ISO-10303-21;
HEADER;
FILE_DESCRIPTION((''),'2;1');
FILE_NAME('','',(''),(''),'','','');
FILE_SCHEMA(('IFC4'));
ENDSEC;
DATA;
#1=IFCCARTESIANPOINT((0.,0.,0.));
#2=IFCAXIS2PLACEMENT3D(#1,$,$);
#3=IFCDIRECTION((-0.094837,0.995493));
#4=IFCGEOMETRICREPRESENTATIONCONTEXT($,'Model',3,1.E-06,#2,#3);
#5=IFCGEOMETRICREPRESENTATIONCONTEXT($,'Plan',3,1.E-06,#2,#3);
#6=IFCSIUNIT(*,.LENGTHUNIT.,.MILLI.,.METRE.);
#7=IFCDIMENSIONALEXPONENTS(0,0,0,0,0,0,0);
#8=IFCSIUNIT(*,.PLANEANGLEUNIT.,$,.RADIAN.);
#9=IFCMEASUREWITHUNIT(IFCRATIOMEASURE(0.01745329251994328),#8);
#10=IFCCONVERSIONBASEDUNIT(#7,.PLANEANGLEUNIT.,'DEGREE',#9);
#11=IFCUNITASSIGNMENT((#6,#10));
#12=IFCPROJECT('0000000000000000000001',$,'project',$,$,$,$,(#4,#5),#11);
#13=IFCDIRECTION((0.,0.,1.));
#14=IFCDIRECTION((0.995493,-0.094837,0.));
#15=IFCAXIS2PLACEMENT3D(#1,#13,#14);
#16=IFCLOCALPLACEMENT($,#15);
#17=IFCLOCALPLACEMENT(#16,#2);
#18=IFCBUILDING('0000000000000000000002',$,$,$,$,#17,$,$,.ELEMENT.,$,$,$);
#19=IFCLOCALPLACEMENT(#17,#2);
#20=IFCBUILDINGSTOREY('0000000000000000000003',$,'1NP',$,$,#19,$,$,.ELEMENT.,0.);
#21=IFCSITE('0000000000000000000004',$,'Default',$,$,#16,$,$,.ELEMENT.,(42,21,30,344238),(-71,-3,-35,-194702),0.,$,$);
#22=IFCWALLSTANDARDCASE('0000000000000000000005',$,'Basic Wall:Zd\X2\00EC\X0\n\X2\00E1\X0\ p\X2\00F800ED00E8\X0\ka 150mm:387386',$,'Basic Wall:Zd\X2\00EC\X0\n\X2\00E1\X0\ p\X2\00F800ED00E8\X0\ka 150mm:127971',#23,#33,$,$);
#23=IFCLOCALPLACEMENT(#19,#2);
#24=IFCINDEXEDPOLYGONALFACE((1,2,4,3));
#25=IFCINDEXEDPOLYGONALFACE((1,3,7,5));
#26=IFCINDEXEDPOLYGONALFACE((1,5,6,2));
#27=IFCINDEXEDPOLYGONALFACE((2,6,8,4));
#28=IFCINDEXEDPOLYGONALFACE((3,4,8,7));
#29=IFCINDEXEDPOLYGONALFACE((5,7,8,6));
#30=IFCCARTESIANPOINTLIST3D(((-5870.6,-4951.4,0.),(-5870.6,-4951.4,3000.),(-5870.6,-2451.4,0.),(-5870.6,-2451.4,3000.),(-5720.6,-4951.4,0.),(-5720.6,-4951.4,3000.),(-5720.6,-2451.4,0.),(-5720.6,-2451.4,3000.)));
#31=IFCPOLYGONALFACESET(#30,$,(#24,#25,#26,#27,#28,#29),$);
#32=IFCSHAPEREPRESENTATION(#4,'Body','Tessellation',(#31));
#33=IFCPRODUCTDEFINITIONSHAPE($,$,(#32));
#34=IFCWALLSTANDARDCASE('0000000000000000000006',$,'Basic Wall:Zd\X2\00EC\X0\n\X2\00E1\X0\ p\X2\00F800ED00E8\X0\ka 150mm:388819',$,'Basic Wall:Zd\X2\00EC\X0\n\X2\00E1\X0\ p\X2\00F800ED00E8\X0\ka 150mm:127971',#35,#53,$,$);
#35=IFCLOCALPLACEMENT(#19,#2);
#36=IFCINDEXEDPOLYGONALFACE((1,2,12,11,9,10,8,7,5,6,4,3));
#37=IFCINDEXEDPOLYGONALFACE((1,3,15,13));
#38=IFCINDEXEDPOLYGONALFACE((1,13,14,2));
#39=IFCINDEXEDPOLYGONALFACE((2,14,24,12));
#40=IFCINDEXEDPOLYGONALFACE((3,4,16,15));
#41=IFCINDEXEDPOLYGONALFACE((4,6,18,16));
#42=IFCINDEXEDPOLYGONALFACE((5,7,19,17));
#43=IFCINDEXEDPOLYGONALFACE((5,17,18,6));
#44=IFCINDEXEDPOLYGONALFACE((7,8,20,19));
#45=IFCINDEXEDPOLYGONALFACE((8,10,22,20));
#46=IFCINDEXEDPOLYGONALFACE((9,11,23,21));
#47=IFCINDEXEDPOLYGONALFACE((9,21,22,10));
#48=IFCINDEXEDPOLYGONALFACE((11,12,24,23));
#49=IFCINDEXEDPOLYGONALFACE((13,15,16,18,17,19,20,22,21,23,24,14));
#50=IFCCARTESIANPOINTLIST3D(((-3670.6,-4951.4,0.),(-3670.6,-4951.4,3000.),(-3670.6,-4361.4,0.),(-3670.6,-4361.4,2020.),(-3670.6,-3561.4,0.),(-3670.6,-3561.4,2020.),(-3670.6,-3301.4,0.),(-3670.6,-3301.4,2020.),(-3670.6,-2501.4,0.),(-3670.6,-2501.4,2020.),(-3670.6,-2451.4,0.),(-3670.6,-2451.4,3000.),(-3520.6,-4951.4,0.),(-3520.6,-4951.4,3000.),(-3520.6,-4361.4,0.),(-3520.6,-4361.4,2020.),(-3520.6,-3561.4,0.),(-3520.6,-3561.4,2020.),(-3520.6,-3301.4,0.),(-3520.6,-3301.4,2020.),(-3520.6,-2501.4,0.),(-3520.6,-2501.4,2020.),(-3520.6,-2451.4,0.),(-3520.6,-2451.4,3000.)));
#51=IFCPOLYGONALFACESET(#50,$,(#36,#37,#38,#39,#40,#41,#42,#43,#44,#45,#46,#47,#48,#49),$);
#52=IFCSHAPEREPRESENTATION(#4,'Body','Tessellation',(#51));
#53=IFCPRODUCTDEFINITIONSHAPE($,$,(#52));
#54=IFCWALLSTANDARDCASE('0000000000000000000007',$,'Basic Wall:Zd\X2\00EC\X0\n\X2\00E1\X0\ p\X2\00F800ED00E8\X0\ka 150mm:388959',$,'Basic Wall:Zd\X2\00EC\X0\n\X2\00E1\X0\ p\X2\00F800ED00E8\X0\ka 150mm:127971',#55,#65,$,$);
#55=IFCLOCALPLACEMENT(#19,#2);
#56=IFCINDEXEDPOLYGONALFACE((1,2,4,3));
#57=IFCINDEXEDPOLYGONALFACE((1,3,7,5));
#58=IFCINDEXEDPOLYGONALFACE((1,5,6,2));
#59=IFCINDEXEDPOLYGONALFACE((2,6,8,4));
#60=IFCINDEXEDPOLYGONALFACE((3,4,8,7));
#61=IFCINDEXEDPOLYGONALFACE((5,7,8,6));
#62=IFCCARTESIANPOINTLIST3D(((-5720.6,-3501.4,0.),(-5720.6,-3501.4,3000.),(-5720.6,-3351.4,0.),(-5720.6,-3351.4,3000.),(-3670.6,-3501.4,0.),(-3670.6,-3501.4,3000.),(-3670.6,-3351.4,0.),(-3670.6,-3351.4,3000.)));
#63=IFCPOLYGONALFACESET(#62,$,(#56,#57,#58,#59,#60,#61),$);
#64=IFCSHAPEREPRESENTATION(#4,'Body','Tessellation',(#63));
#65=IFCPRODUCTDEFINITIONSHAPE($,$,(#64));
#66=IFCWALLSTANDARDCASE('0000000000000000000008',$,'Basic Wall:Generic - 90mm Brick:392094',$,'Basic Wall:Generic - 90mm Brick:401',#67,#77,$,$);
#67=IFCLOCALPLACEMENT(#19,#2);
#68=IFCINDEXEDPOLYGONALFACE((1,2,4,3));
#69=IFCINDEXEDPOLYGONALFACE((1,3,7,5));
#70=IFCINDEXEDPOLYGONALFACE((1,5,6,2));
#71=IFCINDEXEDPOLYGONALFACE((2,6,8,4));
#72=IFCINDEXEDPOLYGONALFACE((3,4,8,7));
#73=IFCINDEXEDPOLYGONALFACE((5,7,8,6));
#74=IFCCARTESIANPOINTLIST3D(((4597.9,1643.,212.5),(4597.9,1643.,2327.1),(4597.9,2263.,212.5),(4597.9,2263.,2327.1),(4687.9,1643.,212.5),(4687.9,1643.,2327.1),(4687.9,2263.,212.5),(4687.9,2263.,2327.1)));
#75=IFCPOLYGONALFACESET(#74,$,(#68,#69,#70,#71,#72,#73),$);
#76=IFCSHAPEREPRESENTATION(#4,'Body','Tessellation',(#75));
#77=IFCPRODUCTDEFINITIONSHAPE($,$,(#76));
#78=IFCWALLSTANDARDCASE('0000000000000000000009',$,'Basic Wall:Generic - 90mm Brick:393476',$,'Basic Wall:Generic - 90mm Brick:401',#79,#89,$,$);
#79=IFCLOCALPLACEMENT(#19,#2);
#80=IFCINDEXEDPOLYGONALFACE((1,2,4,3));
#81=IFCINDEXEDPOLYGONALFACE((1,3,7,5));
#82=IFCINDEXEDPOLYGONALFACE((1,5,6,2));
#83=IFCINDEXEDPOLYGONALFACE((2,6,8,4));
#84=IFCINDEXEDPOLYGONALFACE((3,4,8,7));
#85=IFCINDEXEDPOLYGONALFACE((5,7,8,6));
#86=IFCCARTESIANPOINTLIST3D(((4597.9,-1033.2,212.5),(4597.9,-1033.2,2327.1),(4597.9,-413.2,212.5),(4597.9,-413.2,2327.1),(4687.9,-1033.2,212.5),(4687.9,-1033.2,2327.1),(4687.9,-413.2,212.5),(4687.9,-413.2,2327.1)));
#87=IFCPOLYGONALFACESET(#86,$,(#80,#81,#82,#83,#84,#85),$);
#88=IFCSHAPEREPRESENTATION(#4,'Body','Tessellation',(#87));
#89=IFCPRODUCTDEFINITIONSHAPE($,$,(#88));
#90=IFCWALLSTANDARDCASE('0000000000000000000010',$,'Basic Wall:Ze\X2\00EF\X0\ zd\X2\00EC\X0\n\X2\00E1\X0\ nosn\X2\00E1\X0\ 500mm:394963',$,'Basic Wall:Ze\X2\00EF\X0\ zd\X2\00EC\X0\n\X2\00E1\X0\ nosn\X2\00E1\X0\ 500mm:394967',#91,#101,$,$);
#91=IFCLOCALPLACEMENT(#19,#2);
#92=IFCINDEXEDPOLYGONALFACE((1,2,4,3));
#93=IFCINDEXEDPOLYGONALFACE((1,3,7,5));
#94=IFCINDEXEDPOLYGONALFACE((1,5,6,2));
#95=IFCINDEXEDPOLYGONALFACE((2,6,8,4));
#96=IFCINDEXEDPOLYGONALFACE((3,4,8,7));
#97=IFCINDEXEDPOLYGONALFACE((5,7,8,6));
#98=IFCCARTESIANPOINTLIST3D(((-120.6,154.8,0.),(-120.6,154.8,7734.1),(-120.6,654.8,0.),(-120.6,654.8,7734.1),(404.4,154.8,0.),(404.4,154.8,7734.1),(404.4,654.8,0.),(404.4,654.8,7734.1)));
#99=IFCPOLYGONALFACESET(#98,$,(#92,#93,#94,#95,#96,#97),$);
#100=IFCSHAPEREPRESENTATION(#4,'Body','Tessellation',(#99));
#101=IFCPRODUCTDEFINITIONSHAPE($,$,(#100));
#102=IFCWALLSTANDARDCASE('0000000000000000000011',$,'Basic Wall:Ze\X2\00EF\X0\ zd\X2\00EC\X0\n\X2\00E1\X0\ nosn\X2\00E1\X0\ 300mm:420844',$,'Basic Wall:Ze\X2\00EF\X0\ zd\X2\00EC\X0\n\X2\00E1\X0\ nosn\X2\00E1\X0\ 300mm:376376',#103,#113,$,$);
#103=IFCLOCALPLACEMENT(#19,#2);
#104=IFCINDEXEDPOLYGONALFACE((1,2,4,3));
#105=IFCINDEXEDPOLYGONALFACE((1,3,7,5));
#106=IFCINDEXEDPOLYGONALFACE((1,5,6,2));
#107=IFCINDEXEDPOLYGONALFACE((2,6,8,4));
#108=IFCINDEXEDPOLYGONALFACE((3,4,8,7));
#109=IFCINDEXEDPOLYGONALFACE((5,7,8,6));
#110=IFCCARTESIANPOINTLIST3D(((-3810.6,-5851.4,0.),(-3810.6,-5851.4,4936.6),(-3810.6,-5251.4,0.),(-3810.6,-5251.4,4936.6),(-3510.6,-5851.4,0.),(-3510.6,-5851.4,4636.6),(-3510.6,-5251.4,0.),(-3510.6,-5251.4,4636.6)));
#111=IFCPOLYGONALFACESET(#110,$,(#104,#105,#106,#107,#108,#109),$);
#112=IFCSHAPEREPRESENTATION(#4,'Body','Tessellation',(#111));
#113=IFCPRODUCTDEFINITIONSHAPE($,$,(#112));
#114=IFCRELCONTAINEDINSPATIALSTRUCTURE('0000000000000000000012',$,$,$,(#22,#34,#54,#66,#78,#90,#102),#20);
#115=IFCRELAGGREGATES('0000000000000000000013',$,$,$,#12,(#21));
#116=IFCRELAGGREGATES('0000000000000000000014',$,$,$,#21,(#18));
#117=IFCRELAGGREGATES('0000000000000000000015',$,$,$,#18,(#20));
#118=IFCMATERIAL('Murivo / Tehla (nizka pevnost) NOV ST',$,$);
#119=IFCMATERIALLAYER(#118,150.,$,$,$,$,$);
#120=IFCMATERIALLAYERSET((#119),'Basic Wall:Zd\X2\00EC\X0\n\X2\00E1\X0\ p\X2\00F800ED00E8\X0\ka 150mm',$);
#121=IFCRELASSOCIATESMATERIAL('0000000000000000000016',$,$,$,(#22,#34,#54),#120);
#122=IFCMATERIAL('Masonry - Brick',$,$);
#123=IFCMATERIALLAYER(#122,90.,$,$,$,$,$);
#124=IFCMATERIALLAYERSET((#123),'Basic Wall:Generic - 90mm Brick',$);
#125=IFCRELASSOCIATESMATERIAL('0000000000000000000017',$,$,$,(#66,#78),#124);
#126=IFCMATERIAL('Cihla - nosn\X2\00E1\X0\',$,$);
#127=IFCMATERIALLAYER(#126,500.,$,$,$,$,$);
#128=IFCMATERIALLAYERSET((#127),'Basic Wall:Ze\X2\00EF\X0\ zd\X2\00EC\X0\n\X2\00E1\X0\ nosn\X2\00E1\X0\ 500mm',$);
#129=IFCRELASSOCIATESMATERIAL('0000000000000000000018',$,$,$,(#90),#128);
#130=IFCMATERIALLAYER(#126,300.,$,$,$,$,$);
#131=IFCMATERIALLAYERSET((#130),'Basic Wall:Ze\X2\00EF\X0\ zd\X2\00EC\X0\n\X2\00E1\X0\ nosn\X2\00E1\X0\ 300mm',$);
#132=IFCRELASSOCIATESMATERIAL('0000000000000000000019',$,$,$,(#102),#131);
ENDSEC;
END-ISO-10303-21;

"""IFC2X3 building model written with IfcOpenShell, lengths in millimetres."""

from ifc_helpers import new_model, entity, si_unit, converted_unit, direction, frame, frame_2d, origin, place, context, project, spatial, polyline, rectangle, extrude, clip, bounded_halfspace, material, layer, layer_set, layer_usage, element, save


model = new_model("IFC2X3")

# Units and contexts
model_context = context("Model", 3, precision=1e-06, world=origin(), true_north=direction((-0.094837, 0.995493)))
plan_context = context("Plan", 3, precision=1e-06, world=origin(), true_north=direction((-0.094837, 0.995493)))
ifc_project = project(units=[si_unit("LENGTHUNIT", "METRE", prefix="MILLI"), converted_unit("PLANEANGLEUNIT", "DEGREE", entity("IfcRatioMeasure", 0.01745329251994328), si_unit("PLANEANGLEUNIT", "RADIAN"), dimensions=[0, 0, 0, 0, 0, 0, 0])], contexts=[model_context, plan_context])

# Site, building, storey
site_placement = place(None, frame((0.0, 0.0, 0.0), z_axis=(0.0, 0.0, 1.0), x_axis=(0.995493, -0.094837, 0.0)))
site = spatial("IfcSite", under=ifc_project, at=site_placement, Name="Default", CompositionType="ELEMENT", RefLatitude=(42, 21, 30, 344238), RefLongitude=(-71, -3, -35, -194702), RefElevation=0.0)
building_placement = place(site_placement, origin())
building = spatial("IfcBuilding", under=site, at=building_placement, CompositionType="ELEMENT")
storey_placement = place(building_placement, origin())
storey = spatial("IfcBuildingStorey", under=building, at=storey_placement, Name="1NP", CompositionType="ELEMENT", Elevation=0.0)

# Shared definitions
wall_1_placement = place(storey_placement, frame((-3595.6, -2451.4, 0.0), z_axis=(0.0, 0.0, 1.0), x_axis=(0.0, -1.0, 0.0)))
opening_1_placement = place(wall_1_placement, frame((850.0, 75.0, 0.0)))
opening_2_placement = place(wall_1_placement, frame((1910.0, 75.0, 0.0)))

# Shared definitions
ifc_material_1 = material(Name="Cihla - nosná")
ifc_layer_1 = layer(ifc_material_1, 300.0)
ifc_layer_set_1 = layer_set([ifc_layer_1], Name="Basic Wall:Zeï zdìná nosná 300mm")

# Wall
ifc_material_2 = material(Name="Murivo / Tehla (nizka pevnost) NOV ST")
ifc_layer_2 = layer(ifc_material_2, 150.0)
ifc_layer_set_2 = layer_set([ifc_layer_2], Name="Basic Wall:Zdìná pøíèka 150mm")
ifc_layer_usage_1 = layer_usage(ifc_layer_set_2, "AXIS2", "NEGATIVE", 75.0)
wall_2_placement = place(storey_placement, frame((-5795.6, -2451.4, 0.0), z_axis=(0.0, 0.0, 1.0), x_axis=(0.0, -1.0, 0.0)))
element("IfcWallStandardCase", 1, at=wall_2_placement, inside=storey, material=ifc_layer_usage_1, Name="Basic Wall:Zdìná pøíèka 150mm:387386", ObjectType="Basic Wall:Zdìná pøíèka 150mm:127971", context=model_context, shape_type="SweptSolid", body=[
    extrude(rectangle(XDim=2500.0, YDim=150.0, at=frame_2d((1250.0, 0.0), x_axis=(-1.0, 0.0))), origin(), (0.0, 0.0, 1.0), 3000.0),
])

# Wall, openings
ifc_layer_usage_2 = layer_usage(ifc_layer_set_2, "AXIS2", "NEGATIVE", 75.0)
wall_1 = element("IfcWallStandardCase", 2, at=wall_1_placement, inside=storey, material=ifc_layer_usage_2, Name="Basic Wall:Zdìná pøíèka 150mm:388819", ObjectType="Basic Wall:Zdìná pøíèka 150mm:127971", context=model_context, shape_type="SweptSolid", body=[
    extrude(rectangle(XDim=2500.0, YDim=150.0, at=frame_2d((1250.0, 0.0), x_axis=(-1.0, 0.0))), origin(), (0.0, 0.0, 1.0), 3000.0),
])
element("IfcOpeningElement", 3, at=opening_1_placement, cuts=wall_1, ObjectType="Opening", context=model_context, shape_type="SweptSolid", body=[
    extrude(rectangle(XDim=2020.0, YDim=800.0, at=frame_2d((1010.0, 400.0), x_axis=(1.0, 0.0))), frame((0.0, 0.0, 0.0), z_axis=(0.0, -1.0, 0.0), x_axis=(0.0, 0.0, 1.0)), (0.0, 0.0, 1.0), 150.0),
])
element("IfcOpeningElement", 4, at=opening_2_placement, cuts=wall_1, ObjectType="Opening", context=model_context, shape_type="SweptSolid", body=[
    extrude(rectangle(XDim=2020.0, YDim=800.0, at=frame_2d((1010.0, 400.0), x_axis=(1.0, 0.0))), frame((0.0, 0.0, 0.0), z_axis=(0.0, -1.0, 0.0), x_axis=(0.0, 0.0, 1.0)), (0.0, 0.0, 1.0), 150.0),
])

# Walls
ifc_layer_usage_3 = layer_usage(ifc_layer_set_2, "AXIS2", "NEGATIVE", 75.0)
wall_3_placement = place(storey_placement, frame((-5720.6, -3426.4, 0.0)))
element("IfcWallStandardCase", 5, at=wall_3_placement, inside=storey, material=ifc_layer_usage_3, Name="Basic Wall:Zdìná pøíèka 150mm:388959", ObjectType="Basic Wall:Zdìná pøíèka 150mm:127971", context=model_context, shape_type="SweptSolid", body=[
    extrude(rectangle(XDim=2050.0, YDim=150.0, at=frame_2d((1025.0, 0.0), x_axis=(-1.0, 0.0))), origin(), (0.0, 0.0, 1.0), 3000.0),
])
ifc_material_3 = material(Name="Masonry - Brick")
ifc_layer_3 = layer(ifc_material_3, 90.0)
ifc_layer_set_3 = layer_set([ifc_layer_3], Name="Basic Wall:Generic - 90mm Brick")
ifc_layer_usage_4 = layer_usage(ifc_layer_set_3, "AXIS2", "NEGATIVE", 45.0)
wall_4_placement = place(storey_placement, frame((4642.9, 1643.0, 212.5), z_axis=(0.0, 0.0, 1.0), x_axis=(0.0, 1.0, 0.0)))
element("IfcWallStandardCase", 6, at=wall_4_placement, inside=storey, material=ifc_layer_usage_4, Name="Basic Wall:Generic - 90mm Brick:392094", ObjectType="Basic Wall:Generic - 90mm Brick:401", context=model_context, shape_type="SweptSolid", body=[
    extrude(rectangle(XDim=620.0, YDim=90.0, at=frame_2d((310.0, 0.0), x_axis=(-1.0, 0.0))), origin(), (0.0, 0.0, 1.0), 2114.6),
])
ifc_layer_usage_5 = layer_usage(ifc_layer_set_3, "AXIS2", "NEGATIVE", 45.0)
wall_5_placement = place(storey_placement, frame((4642.9, -1033.2, 212.5), z_axis=(0.0, 0.0, 1.0), x_axis=(0.0, 1.0, 0.0)))
element("IfcWallStandardCase", 7, at=wall_5_placement, inside=storey, material=ifc_layer_usage_5, Name="Basic Wall:Generic - 90mm Brick:393476", ObjectType="Basic Wall:Generic - 90mm Brick:401", context=model_context, shape_type="SweptSolid", body=[
    extrude(rectangle(XDim=620.0, YDim=90.0, at=frame_2d((310.0, 0.0), x_axis=(-1.0, 0.0))), origin(), (0.0, 0.0, 1.0), 2114.6),
])
ifc_layer_4 = layer(ifc_material_1, 500.0)
ifc_layer_set_4 = layer_set([ifc_layer_4], Name="Basic Wall:Zeï zdìná nosná 500mm")
ifc_layer_usage_6 = layer_usage(ifc_layer_set_4, "AXIS2", "NEGATIVE", 250.0)
wall_6_placement = place(storey_placement, frame((-120.6, 404.8, 0.0)))
element("IfcWallStandardCase", 8, at=wall_6_placement, inside=storey, material=ifc_layer_usage_6, Name="Basic Wall:Zeï zdìná nosná 500mm:394963", ObjectType="Basic Wall:Zeï zdìná nosná 500mm:394967", context=model_context, shape_type="SweptSolid", body=[
    extrude(rectangle(XDim=525.0, YDim=500.0, at=frame_2d((262.5, 0.0), x_axis=(-1.0, 0.0))), origin(), (0.0, 0.0, 1.0), 7734.1),
])
ifc_layer_usage_7 = layer_usage(ifc_layer_set_1, "AXIS2", "POSITIVE", -150.0)
wall_7_placement = place(storey_placement, frame((-3660.6, -5851.4, 0.0), z_axis=(0.0, 0.0, 1.0), x_axis=(0.0, 1.0, 0.0)))
element("IfcWallStandardCase", 9, at=wall_7_placement, inside=storey, material=ifc_layer_usage_7, Name="Basic Wall:Zeï zdìná nosná 300mm:420844", ObjectType="Basic Wall:Zeï zdìná nosná 300mm:376376", context=model_context, shape_type="Clipping", body=[
    clip(extrude(rectangle(XDim=600.0, YDim=300.0, at=frame_2d((300.0, 0.0), x_axis=(-1.0, 0.0))), origin(), (0.0, 0.0, 1.0), 4936.6), bounded_halfspace(frame((0.0, -150.0, 4636.6), z_axis=(0.0, -0.707107, 0.707107), x_axis=(1.0, 0.0, 0.0)), False, frame((0.0, -150.0, 4636.6)), polyline([(0.0, 0.0), (600.0, 0.0), (600.0, 300.0), (0.0, 300.0), (0.0, 0.0)]))),
])

save(model, "model.ifc")
